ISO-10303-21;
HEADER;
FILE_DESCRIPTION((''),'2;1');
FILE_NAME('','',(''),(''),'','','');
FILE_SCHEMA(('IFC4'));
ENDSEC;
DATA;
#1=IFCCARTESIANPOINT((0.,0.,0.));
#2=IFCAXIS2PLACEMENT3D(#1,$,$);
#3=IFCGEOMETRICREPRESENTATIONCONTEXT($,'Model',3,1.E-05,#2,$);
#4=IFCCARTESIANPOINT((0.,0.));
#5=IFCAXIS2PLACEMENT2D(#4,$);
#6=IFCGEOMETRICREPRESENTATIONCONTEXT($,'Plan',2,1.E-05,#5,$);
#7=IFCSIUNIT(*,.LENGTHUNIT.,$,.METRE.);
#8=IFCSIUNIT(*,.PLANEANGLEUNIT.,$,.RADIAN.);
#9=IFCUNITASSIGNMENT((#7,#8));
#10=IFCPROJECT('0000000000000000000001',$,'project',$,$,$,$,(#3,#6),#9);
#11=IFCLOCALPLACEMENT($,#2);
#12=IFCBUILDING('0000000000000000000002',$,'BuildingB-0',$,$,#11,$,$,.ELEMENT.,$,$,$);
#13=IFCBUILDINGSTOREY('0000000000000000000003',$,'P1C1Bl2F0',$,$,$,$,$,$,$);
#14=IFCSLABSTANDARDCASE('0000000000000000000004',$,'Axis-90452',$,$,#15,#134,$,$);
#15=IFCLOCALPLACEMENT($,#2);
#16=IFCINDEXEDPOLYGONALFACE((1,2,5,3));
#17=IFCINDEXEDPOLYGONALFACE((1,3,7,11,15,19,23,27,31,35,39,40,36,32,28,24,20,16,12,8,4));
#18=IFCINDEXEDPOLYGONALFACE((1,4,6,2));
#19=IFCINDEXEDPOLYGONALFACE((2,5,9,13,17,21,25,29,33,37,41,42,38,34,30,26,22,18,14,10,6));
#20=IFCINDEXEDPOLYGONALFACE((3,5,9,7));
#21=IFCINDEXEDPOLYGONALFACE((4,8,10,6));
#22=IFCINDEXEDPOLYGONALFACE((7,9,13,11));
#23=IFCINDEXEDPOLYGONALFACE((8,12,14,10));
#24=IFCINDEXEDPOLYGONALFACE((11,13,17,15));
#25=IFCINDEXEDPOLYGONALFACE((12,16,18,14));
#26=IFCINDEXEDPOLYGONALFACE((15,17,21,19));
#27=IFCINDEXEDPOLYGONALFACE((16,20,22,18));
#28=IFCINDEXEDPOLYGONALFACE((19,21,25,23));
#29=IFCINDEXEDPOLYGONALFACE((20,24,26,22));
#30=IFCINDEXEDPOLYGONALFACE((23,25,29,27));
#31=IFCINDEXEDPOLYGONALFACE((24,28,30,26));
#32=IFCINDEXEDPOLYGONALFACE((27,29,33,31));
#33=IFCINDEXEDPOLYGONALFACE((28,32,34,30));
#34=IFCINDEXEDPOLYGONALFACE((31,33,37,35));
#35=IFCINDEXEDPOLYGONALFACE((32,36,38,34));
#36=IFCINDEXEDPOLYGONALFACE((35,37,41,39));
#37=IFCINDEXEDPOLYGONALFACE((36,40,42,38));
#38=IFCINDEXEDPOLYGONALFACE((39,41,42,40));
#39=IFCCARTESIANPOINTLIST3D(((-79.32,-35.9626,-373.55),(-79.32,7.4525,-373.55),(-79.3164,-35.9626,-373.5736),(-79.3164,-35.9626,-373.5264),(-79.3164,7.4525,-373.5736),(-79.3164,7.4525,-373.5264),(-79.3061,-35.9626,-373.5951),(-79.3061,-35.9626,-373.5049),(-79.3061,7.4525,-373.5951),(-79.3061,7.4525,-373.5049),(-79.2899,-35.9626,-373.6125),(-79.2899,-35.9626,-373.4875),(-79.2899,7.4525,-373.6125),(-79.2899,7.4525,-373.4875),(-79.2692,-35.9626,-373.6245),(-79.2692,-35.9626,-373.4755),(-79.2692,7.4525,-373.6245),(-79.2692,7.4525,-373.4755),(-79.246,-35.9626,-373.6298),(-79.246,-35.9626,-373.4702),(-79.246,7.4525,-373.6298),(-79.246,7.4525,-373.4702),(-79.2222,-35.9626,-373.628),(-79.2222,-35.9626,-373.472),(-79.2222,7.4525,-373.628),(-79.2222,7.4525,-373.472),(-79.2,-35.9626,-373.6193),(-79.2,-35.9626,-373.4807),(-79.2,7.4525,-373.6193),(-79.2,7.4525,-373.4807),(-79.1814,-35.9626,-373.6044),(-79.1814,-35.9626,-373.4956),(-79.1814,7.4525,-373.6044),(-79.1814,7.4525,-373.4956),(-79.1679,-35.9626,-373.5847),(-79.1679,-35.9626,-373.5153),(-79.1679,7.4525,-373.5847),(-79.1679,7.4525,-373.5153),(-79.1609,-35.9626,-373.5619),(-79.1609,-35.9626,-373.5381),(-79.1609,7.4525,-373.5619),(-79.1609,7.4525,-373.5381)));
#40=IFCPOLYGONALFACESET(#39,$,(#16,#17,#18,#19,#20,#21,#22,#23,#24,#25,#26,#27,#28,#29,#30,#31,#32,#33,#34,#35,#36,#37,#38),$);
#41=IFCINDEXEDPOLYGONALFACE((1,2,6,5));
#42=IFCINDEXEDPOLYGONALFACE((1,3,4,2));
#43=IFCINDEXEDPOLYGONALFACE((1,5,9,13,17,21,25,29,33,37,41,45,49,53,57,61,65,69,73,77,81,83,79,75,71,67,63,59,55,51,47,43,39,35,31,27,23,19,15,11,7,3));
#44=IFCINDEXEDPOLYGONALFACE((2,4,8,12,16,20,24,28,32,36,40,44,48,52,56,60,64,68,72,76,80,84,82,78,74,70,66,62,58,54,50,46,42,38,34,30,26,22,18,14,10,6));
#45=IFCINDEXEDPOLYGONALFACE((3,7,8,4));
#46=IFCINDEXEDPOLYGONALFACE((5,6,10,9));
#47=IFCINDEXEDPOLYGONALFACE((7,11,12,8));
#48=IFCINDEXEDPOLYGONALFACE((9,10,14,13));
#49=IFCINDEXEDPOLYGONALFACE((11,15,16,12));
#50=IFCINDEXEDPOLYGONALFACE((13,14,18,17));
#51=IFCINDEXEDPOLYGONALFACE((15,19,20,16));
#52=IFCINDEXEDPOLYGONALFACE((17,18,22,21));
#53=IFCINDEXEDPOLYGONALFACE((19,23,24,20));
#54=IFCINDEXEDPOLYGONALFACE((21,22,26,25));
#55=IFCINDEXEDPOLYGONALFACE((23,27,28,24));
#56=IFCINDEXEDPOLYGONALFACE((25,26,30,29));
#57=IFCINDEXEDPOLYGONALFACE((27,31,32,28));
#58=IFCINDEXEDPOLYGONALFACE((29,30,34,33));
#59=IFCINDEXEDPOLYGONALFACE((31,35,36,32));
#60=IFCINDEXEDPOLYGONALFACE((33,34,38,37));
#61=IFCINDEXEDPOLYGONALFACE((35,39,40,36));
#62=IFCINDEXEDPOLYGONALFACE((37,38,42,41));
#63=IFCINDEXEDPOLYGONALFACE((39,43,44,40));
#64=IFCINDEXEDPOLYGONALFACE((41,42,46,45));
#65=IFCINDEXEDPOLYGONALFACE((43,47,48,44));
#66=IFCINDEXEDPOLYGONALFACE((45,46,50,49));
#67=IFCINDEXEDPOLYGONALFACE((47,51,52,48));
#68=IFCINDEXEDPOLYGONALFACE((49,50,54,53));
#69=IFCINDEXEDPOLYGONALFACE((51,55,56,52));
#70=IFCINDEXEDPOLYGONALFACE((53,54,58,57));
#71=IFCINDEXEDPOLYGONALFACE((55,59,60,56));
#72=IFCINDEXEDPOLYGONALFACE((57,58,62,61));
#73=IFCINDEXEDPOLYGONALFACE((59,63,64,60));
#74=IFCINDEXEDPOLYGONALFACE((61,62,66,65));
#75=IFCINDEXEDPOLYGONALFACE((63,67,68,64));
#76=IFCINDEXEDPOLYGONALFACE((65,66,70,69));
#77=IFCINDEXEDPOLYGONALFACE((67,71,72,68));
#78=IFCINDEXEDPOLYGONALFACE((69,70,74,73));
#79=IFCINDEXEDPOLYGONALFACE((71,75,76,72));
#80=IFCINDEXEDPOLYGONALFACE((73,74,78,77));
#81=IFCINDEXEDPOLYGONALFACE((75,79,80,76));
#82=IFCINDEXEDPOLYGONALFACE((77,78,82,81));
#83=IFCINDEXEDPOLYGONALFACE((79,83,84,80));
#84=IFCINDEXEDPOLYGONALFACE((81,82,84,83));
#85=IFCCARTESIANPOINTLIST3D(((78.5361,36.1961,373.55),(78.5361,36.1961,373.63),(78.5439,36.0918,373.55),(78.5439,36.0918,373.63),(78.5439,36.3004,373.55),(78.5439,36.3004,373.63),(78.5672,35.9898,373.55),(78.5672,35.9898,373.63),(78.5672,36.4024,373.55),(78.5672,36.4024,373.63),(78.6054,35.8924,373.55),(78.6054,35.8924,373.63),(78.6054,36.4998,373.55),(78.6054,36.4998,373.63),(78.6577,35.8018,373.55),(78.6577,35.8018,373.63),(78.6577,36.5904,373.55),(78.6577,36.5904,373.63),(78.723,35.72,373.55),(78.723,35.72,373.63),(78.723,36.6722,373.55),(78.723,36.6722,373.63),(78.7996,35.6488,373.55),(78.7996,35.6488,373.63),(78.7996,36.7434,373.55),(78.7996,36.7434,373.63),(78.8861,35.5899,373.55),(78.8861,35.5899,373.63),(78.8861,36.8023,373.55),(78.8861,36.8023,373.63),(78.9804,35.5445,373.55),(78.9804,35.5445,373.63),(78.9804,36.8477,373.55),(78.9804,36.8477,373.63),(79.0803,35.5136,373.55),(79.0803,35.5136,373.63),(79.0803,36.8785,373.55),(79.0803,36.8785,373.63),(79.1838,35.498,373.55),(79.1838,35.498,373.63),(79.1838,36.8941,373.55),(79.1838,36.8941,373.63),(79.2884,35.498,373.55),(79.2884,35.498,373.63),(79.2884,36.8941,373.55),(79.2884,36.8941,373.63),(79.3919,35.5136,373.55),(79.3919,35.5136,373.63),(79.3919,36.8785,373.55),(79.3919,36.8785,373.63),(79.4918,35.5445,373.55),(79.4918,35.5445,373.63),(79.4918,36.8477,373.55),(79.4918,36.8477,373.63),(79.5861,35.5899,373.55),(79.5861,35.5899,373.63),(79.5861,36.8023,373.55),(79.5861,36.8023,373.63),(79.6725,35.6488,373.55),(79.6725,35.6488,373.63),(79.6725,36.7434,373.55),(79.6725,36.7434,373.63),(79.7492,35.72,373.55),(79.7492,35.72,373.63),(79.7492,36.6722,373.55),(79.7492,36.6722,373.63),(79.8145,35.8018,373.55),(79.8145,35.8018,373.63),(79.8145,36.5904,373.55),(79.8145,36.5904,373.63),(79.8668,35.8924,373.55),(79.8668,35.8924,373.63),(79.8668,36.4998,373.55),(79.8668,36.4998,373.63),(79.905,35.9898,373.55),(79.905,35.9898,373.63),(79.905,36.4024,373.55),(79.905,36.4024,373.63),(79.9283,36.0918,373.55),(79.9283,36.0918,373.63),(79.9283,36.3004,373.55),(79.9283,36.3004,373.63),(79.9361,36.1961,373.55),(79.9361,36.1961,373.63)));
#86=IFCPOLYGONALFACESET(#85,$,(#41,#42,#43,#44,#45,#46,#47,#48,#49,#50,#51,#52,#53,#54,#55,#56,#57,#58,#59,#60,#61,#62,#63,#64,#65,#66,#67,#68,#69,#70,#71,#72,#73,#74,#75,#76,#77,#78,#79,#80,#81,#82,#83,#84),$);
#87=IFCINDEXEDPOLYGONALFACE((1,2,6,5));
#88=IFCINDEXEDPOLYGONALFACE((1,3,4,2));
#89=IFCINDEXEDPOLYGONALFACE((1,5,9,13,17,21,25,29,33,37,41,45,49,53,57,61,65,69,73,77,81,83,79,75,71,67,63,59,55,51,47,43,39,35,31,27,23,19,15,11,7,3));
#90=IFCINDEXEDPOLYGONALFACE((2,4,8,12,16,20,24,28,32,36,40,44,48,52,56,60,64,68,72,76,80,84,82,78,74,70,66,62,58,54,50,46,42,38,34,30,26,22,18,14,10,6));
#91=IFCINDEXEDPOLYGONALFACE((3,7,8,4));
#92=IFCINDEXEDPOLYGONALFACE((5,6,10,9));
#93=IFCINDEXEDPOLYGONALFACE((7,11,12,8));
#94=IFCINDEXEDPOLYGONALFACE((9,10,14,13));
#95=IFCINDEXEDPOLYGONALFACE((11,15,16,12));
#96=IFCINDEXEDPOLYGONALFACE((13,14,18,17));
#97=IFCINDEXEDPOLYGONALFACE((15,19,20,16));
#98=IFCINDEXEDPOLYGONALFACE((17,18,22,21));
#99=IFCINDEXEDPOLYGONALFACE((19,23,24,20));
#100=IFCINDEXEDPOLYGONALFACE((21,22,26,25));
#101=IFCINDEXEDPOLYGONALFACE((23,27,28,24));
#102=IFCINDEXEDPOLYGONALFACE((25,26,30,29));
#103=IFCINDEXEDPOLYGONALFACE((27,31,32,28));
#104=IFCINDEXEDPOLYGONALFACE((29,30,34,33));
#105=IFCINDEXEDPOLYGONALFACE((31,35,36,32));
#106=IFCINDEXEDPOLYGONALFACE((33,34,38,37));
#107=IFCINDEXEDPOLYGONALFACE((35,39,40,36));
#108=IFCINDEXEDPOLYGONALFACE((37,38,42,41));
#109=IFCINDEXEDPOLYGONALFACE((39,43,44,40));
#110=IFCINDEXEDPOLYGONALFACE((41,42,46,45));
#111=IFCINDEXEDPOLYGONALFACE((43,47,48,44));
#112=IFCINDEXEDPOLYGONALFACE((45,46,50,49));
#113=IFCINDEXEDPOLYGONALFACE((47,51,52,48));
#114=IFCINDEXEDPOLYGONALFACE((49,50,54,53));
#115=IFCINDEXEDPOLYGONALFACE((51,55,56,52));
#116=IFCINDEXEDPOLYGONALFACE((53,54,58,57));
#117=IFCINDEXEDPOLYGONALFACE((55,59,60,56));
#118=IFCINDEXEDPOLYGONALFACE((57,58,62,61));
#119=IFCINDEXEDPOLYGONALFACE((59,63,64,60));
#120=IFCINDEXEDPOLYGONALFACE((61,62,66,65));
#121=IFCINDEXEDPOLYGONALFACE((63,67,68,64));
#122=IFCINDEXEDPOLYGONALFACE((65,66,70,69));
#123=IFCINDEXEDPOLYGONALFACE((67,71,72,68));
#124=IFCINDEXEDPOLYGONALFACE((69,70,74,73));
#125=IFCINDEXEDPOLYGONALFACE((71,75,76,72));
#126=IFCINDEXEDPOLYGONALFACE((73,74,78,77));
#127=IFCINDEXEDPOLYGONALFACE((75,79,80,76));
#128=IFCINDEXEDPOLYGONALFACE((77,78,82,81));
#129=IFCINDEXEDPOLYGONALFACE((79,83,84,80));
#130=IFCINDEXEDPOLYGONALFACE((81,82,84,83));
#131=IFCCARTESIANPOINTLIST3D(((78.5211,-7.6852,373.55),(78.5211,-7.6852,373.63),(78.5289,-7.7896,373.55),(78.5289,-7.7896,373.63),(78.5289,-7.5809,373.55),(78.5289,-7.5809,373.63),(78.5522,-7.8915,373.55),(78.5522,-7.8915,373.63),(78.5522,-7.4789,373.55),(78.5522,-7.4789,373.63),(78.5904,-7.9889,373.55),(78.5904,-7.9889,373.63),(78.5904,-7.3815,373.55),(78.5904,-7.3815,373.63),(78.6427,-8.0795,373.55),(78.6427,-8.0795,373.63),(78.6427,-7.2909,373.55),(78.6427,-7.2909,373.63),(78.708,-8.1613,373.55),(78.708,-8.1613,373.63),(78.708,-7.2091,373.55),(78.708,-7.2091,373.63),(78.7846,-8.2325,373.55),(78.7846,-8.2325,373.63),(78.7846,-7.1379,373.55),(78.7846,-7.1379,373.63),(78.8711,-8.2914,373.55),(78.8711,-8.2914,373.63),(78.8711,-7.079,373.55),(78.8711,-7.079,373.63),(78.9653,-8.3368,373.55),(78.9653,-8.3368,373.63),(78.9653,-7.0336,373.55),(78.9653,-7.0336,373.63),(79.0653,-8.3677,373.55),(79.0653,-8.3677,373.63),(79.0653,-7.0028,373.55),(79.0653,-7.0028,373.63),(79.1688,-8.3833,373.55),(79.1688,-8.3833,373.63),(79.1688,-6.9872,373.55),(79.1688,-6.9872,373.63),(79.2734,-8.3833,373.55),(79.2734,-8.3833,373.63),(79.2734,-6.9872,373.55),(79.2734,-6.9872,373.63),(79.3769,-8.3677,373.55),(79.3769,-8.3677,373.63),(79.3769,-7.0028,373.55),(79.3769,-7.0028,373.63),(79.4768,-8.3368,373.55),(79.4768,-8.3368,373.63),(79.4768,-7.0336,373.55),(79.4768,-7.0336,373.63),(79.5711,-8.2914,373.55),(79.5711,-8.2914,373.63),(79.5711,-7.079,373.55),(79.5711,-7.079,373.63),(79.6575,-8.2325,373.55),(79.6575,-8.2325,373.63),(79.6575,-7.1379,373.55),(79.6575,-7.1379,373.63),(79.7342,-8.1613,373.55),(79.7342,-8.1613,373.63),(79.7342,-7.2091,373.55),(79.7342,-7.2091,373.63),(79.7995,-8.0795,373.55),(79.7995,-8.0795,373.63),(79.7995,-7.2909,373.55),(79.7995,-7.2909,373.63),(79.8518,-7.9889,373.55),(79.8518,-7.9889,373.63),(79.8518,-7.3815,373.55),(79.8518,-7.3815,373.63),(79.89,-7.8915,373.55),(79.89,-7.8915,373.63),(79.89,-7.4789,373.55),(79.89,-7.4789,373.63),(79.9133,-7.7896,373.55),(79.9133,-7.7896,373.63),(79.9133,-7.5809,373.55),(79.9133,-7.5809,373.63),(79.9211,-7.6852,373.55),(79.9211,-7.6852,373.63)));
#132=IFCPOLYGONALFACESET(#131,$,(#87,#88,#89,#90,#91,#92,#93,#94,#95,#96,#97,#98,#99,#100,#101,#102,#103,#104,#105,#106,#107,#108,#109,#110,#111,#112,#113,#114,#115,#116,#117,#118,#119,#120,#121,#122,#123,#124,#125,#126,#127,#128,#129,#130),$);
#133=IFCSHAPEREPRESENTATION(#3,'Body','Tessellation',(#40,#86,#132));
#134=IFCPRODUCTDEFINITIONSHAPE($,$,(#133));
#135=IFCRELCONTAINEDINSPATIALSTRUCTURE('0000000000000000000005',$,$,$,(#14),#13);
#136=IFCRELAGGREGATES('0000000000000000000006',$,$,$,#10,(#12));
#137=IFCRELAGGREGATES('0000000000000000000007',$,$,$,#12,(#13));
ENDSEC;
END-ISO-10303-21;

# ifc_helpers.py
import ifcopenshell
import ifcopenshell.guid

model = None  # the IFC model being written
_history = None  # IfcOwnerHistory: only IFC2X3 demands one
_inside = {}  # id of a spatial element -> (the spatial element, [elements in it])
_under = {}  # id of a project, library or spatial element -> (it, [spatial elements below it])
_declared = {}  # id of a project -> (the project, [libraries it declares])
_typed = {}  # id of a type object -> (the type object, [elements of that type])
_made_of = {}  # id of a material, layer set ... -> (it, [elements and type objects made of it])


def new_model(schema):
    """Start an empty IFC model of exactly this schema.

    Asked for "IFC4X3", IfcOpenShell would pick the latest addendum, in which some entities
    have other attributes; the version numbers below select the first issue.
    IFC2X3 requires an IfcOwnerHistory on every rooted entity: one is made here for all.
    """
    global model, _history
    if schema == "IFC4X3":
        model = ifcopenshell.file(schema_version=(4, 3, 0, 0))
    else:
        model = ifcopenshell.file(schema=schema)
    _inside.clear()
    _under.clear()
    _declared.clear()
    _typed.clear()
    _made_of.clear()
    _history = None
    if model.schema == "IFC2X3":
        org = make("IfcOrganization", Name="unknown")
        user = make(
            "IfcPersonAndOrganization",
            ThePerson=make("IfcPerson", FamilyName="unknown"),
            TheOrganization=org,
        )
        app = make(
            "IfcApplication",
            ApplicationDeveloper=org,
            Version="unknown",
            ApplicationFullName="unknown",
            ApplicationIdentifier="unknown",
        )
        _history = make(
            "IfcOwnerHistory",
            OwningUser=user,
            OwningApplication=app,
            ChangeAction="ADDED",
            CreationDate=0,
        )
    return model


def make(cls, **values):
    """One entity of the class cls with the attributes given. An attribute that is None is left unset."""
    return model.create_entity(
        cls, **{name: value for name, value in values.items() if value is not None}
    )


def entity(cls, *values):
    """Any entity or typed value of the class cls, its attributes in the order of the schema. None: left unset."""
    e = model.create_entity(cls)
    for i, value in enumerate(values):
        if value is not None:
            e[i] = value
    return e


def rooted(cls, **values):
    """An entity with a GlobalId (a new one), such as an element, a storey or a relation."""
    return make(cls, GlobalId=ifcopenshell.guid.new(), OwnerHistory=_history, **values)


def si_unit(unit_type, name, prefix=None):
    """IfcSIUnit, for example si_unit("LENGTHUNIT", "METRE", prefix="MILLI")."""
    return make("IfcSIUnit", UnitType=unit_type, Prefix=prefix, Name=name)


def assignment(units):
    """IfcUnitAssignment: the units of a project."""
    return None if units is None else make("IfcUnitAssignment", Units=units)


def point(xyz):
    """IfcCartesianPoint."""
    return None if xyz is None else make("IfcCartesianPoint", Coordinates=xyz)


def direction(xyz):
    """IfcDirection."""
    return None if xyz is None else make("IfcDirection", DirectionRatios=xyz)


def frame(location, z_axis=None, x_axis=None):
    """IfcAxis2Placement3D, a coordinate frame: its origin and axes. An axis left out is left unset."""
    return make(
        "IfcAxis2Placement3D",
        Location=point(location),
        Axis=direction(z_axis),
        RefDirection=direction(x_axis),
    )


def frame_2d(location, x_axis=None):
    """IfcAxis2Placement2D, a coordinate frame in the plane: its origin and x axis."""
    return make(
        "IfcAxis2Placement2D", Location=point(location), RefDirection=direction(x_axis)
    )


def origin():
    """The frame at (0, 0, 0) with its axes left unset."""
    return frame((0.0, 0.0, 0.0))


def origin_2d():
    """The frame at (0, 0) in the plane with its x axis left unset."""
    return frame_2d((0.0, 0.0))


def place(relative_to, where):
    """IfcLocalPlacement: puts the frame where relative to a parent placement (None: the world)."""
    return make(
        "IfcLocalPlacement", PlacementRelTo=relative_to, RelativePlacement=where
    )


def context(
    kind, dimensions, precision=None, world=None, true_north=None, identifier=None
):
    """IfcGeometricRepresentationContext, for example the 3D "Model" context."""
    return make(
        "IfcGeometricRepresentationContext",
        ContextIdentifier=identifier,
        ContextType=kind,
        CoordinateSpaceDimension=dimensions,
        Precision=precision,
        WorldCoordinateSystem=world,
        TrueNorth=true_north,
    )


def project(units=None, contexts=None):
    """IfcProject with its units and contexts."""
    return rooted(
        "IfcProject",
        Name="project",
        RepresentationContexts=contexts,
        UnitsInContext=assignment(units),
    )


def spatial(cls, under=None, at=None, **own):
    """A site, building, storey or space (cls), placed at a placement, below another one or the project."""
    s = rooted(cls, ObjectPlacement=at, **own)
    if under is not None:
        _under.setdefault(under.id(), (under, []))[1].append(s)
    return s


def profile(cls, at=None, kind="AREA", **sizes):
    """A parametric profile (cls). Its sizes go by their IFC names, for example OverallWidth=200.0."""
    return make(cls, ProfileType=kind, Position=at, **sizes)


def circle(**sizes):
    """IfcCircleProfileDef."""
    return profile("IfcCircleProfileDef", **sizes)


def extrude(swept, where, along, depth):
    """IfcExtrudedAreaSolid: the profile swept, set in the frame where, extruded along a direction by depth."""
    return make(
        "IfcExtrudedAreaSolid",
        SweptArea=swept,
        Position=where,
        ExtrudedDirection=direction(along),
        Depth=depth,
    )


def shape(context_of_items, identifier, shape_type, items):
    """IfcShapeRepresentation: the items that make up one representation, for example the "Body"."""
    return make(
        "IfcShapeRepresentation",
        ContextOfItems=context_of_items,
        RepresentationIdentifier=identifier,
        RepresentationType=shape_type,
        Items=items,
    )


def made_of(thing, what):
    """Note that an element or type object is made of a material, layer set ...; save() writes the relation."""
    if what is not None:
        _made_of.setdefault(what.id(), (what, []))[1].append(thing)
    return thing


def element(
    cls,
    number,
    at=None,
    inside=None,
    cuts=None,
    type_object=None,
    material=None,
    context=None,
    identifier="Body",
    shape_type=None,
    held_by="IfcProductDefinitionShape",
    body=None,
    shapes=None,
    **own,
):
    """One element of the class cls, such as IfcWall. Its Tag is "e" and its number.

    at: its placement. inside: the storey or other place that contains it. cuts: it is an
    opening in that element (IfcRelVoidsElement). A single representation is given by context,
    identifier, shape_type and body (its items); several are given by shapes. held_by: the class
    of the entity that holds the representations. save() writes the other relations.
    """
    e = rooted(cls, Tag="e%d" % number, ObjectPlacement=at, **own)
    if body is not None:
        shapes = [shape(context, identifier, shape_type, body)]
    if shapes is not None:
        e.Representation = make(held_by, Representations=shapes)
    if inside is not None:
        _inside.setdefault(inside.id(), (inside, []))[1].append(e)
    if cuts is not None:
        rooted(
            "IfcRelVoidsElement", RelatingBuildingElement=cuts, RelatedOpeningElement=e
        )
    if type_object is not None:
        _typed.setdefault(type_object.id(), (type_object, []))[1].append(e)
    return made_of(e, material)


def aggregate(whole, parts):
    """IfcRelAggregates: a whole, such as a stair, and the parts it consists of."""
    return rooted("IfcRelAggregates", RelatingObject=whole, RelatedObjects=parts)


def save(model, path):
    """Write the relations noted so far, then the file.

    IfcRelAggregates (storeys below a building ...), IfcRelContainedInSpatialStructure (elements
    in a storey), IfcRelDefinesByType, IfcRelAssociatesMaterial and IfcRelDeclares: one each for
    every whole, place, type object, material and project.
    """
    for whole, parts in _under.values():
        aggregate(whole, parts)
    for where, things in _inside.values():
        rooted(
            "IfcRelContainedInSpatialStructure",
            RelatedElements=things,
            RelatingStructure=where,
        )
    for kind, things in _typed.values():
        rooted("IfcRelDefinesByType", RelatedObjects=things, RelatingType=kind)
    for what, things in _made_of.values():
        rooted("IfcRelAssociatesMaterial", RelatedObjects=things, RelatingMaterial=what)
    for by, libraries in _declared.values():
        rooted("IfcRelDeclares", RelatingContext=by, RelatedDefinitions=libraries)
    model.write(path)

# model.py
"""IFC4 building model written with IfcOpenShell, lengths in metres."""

from ifc_helpers import new_model, entity, si_unit, frame, origin, origin_2d, place, context, project, spatial, circle, extrude, element, save


model = new_model("IFC4")

# Units and contexts
model_context = context("Model", 3, precision=1e-05, world=origin())
plan_context = context("Plan", 2, precision=1e-05, world=origin_2d())
ifc_project = project(units=[si_unit("LENGTHUNIT", "METRE"), si_unit("PLANEANGLEUNIT", "RADIAN")], contexts=[model_context, plan_context])

# Building, storey
building_placement = place(None, origin())
building = spatial("IfcBuilding", under=ifc_project, at=building_placement, Name="BuildingB-0", CompositionType="ELEMENT")
storey = spatial("IfcBuildingStorey", under=building, Name="P1C1Bl2F0")

# Slab
element("IfcSlabStandardCase", 1, inside=storey, Name="Axis-90452", context=model_context, shape_type="AdvancedSweptSolid", body=[
    entity("IfcSurfaceCurveSweptAreaSolid", entity("IfcCircleProfileDef", "AREA", None, None, 0.08), None, entity("IfcPolyline", [entity("IfcCartesianPoint", [79.24, 35.9626, 373.55]), entity("IfcCartesianPoint", [79.24, -7.4525, 373.55])]), None, None, entity("IfcPlane", entity("IfcAxis2Placement3D", entity("IfcCartesianPoint", [79.24, 35.9626, 373.55]), entity("IfcDirection", [0.0, 0.0, 1.0]), entity("IfcDirection", [1.0, 0.0, 0.0])))),
    extrude(circle(Radius=0.7), frame((79.2361, 36.1961, 373.55)), (0.0, 0.0, 1.0), 0.08),
    extrude(circle(Radius=0.7), frame((79.2211, -7.6852, 373.55)), (0.0, 0.0, 1.0), 0.08),
])

save(model, "model.ifc")
